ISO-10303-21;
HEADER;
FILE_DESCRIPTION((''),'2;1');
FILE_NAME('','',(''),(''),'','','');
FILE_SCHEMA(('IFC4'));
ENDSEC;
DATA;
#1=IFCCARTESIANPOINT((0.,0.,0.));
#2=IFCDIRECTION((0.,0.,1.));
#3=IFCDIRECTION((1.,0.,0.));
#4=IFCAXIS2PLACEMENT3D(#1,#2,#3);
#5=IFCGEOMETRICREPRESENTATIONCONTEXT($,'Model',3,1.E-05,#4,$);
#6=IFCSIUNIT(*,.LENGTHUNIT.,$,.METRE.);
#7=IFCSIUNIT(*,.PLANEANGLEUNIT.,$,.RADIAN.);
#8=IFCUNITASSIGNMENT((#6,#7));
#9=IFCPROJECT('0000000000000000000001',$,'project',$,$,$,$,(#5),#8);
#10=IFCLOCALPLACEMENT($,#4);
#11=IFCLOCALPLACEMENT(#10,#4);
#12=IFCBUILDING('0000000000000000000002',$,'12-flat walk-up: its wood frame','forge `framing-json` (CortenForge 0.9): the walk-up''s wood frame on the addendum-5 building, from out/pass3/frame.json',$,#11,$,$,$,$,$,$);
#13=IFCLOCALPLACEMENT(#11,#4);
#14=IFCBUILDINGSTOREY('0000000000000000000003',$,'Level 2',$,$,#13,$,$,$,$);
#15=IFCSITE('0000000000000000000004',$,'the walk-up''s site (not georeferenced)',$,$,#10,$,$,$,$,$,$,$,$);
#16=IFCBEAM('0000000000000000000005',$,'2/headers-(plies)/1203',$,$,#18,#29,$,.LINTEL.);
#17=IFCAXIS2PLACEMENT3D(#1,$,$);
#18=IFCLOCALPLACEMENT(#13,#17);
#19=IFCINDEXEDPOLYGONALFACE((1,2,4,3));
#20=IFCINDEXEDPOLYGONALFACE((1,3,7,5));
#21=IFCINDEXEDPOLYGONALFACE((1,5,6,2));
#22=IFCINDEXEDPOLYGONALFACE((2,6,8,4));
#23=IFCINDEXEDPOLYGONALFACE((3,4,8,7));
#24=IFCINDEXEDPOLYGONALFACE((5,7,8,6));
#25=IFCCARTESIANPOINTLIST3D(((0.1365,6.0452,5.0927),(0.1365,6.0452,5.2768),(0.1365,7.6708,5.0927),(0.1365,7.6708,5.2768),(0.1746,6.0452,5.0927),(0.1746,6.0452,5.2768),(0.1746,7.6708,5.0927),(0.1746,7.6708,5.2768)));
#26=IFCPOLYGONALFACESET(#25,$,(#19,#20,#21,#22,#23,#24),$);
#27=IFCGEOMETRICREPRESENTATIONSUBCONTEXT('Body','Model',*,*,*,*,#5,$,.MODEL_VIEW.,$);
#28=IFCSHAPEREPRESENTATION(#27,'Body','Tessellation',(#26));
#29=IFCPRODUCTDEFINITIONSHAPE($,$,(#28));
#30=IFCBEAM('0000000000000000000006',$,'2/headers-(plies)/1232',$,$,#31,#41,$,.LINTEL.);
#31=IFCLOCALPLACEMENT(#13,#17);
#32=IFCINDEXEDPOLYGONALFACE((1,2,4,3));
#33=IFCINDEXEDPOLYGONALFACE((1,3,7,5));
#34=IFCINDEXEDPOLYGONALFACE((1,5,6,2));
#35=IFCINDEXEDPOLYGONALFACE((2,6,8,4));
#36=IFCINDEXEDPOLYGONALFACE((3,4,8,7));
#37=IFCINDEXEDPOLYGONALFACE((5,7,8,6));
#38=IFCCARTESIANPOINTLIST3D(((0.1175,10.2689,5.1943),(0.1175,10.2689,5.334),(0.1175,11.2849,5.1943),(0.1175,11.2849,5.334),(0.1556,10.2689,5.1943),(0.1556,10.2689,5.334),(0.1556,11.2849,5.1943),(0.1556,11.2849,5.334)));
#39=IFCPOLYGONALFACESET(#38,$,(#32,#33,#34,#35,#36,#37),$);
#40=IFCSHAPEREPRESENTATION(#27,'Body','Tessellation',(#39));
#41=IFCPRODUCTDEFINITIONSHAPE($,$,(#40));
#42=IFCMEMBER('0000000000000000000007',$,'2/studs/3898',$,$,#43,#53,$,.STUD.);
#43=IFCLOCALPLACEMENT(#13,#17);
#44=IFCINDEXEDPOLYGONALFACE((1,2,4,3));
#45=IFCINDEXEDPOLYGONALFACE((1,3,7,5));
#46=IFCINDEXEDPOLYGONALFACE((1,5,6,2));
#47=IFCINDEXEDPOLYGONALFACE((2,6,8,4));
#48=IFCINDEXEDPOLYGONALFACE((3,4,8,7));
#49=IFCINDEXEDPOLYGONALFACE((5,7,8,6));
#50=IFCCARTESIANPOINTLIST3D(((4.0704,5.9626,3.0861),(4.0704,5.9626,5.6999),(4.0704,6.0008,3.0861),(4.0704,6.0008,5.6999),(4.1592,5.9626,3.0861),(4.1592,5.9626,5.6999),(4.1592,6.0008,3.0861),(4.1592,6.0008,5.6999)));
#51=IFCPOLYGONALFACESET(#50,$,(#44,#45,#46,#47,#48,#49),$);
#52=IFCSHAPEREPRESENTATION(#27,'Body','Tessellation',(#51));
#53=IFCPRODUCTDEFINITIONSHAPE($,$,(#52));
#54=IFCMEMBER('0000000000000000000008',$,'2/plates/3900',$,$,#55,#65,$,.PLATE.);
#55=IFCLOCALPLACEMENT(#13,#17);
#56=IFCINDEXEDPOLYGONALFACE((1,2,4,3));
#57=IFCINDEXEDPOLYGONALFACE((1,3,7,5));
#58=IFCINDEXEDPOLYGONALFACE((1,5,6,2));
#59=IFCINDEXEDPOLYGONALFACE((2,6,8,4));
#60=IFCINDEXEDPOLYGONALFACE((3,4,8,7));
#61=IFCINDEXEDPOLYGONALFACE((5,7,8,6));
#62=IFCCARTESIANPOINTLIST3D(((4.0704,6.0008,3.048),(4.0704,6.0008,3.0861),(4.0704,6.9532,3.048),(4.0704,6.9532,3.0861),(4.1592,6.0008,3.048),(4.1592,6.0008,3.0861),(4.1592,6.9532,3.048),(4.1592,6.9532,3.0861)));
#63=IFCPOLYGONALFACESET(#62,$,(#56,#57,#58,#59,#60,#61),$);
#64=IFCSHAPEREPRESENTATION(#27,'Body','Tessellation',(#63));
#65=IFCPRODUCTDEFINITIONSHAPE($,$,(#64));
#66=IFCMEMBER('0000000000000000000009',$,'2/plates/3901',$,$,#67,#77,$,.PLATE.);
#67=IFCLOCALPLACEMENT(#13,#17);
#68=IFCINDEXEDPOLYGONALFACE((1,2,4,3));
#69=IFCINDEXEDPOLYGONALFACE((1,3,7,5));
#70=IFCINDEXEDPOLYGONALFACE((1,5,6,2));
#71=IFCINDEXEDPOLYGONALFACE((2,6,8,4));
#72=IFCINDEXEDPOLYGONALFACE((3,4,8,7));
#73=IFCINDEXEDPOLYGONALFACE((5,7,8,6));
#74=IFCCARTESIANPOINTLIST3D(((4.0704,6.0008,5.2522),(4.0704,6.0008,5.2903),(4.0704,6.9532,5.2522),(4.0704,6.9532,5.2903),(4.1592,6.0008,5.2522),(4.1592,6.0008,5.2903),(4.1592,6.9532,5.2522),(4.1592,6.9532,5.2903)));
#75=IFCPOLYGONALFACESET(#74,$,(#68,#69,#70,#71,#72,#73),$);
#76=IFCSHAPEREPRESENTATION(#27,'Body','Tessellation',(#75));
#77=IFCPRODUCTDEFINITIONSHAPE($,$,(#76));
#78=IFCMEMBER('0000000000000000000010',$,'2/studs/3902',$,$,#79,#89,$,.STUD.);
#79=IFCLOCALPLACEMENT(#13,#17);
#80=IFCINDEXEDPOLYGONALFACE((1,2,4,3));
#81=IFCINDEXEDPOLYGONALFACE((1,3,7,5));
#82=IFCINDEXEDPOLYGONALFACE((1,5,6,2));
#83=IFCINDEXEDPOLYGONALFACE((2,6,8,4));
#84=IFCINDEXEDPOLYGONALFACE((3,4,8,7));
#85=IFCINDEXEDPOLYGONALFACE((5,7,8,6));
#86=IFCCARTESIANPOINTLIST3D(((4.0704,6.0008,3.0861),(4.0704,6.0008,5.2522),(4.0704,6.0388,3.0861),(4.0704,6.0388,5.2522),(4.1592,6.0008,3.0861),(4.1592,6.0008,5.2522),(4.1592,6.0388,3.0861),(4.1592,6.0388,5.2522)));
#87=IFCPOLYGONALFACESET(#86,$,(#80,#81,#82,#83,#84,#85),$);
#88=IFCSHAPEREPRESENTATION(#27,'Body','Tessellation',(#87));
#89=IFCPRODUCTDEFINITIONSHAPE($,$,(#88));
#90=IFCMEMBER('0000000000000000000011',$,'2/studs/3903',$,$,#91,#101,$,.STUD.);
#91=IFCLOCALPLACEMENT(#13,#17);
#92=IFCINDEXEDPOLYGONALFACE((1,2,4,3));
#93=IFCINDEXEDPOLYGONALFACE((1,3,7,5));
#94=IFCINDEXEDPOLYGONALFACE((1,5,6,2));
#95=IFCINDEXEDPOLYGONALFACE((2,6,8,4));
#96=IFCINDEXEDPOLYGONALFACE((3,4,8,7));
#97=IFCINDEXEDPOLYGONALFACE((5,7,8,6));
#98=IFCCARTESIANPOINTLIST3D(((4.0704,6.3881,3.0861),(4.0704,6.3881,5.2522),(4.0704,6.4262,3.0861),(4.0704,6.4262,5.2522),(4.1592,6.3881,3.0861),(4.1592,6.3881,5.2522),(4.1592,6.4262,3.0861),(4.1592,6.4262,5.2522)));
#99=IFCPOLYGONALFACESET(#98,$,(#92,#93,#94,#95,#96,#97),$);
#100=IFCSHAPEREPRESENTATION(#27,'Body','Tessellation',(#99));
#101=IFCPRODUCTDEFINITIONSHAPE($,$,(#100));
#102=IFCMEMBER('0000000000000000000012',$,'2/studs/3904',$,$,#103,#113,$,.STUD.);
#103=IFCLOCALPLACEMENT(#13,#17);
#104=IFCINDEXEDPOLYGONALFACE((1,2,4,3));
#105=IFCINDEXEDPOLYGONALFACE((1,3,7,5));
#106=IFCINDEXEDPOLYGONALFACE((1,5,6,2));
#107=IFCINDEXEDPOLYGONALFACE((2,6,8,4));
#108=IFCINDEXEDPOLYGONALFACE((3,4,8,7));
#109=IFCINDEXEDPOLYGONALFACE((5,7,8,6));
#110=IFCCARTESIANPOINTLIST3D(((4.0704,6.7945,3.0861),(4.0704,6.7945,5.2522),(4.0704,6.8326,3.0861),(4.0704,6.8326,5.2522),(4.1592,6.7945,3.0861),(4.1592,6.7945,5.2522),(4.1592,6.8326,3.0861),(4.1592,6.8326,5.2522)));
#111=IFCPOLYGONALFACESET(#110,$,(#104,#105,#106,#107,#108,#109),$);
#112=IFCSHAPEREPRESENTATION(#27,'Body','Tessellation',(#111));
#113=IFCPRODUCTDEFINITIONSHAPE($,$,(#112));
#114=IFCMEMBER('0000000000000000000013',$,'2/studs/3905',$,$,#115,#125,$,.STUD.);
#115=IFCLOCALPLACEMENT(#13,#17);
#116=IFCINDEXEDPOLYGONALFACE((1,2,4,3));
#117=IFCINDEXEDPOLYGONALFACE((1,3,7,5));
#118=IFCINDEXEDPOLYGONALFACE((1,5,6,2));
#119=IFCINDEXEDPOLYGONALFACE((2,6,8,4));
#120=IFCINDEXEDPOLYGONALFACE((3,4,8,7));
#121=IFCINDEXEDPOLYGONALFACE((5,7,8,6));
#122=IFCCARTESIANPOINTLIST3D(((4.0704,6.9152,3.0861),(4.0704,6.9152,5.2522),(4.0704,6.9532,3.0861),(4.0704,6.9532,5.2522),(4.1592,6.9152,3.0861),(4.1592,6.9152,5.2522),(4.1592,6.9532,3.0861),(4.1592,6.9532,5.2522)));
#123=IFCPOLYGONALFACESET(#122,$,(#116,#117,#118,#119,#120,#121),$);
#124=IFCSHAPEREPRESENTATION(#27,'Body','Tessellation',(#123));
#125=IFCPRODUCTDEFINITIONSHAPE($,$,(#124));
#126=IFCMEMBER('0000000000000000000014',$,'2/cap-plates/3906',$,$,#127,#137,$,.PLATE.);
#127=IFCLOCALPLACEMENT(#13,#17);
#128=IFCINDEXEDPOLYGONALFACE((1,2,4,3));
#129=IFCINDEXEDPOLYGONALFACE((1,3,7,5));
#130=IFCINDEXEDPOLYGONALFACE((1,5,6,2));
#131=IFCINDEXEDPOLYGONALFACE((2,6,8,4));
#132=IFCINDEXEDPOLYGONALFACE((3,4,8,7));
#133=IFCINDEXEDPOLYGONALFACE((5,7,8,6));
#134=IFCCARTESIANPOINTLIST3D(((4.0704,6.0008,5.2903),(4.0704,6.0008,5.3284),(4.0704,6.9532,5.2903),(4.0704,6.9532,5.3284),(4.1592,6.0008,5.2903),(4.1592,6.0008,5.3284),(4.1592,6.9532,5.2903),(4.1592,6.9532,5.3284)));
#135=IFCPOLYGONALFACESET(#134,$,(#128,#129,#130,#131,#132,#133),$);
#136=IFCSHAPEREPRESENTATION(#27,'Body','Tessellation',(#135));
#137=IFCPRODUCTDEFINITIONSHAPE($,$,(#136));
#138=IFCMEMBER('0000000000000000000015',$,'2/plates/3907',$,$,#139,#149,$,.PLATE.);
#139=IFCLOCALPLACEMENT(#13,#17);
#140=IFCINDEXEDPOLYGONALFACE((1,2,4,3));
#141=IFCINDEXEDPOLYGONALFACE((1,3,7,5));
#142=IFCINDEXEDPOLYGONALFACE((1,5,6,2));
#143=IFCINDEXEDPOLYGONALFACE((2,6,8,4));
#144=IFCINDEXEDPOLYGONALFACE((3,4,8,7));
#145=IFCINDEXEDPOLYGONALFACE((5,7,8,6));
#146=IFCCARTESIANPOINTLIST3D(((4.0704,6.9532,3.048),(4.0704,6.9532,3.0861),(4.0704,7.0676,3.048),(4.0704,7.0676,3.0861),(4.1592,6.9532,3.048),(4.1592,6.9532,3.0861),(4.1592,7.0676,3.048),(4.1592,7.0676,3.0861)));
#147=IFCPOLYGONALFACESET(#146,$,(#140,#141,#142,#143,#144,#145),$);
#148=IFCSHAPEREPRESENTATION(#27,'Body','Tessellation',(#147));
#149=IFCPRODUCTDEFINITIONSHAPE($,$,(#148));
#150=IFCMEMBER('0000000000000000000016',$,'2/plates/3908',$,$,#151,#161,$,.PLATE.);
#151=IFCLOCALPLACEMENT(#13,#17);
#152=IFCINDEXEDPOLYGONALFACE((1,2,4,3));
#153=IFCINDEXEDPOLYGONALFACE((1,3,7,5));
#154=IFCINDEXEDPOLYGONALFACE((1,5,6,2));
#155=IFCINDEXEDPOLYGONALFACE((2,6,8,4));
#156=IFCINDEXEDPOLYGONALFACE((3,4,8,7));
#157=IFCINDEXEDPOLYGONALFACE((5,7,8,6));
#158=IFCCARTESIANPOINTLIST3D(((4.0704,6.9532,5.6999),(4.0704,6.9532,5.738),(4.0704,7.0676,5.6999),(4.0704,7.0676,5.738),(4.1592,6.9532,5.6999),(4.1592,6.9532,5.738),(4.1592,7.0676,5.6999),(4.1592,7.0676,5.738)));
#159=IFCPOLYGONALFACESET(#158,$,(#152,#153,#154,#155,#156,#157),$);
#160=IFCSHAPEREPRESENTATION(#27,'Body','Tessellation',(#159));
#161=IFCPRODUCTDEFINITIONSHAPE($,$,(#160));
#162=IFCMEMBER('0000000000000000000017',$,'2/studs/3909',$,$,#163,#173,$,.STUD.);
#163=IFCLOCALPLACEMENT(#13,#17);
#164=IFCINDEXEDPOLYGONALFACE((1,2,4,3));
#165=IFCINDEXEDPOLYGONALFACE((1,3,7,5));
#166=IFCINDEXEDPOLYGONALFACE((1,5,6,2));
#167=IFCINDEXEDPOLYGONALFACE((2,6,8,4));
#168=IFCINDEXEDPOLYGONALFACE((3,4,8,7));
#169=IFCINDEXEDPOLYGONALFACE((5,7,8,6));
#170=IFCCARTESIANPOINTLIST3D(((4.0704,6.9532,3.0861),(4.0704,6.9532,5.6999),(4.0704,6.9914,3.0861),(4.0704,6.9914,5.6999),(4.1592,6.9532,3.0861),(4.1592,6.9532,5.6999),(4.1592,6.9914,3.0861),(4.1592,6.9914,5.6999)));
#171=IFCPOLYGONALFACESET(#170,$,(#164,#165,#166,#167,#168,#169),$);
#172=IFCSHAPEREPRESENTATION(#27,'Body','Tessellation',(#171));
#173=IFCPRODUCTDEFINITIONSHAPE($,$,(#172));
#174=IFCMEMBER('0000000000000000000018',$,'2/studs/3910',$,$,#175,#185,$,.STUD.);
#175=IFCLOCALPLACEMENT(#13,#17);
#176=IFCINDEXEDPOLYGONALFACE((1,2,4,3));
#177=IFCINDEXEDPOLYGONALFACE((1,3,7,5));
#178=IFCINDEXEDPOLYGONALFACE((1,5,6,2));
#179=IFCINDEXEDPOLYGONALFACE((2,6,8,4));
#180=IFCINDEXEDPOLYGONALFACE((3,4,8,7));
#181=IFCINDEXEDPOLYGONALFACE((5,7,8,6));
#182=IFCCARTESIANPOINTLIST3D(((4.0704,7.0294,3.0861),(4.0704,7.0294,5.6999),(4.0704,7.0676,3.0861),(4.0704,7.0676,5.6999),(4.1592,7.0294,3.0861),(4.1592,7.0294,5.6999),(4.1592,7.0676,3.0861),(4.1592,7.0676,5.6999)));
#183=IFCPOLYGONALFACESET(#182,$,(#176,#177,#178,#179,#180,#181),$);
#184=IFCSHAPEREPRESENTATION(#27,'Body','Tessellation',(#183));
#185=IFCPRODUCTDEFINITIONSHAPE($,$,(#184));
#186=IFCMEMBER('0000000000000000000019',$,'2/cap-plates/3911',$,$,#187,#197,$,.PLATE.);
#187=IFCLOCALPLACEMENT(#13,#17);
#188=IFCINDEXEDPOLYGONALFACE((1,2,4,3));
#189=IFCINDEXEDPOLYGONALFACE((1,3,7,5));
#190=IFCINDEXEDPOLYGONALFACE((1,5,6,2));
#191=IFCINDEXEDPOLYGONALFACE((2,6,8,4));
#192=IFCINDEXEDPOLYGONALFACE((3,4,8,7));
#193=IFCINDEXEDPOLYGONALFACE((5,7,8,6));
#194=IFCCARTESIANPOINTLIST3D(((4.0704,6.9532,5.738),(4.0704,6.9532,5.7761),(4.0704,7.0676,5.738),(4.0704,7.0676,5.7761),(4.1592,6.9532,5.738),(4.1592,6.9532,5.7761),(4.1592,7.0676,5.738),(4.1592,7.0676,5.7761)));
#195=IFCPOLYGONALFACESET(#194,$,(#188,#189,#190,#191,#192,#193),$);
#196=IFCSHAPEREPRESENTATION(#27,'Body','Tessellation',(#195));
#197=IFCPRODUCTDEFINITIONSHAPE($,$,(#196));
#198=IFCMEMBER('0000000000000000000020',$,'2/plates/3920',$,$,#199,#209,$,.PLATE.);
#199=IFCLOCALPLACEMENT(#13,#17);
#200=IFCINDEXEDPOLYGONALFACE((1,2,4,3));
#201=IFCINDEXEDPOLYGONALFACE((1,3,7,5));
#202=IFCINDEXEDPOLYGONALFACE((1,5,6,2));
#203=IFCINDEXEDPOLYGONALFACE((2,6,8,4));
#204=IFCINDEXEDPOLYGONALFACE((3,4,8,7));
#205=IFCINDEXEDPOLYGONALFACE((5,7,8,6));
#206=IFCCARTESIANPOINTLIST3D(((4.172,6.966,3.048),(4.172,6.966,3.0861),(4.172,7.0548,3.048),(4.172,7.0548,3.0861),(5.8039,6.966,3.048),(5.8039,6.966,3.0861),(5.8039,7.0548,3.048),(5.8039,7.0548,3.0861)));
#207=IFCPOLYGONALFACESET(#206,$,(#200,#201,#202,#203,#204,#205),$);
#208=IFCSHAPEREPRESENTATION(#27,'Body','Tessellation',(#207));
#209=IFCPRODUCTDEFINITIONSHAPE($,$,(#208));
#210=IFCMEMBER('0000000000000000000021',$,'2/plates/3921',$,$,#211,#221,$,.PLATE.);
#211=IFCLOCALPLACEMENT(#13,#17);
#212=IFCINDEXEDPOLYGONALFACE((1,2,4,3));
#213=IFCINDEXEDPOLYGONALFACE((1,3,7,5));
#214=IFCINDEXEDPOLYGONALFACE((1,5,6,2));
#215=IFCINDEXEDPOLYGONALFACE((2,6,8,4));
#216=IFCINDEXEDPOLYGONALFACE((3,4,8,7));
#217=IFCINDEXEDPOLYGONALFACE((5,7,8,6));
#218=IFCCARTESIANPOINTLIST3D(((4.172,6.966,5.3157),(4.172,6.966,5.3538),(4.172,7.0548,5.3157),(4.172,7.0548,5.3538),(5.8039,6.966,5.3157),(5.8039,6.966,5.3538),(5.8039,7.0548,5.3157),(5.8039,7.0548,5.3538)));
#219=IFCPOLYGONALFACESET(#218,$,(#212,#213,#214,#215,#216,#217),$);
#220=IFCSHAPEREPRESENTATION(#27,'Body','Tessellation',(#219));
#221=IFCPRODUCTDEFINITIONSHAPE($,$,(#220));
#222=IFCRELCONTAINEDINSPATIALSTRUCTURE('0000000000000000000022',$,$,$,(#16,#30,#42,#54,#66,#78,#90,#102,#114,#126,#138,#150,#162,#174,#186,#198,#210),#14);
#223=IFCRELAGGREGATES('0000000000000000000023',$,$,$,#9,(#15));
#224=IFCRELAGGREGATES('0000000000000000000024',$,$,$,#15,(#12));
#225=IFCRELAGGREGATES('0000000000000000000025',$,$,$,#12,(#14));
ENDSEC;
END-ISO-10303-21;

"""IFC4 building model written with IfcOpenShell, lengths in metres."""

from ifc_helpers import new_model, si_unit, frame, frame_2d, origin, origin_with_axes, place, context, subcontext, project, spatial, rectangle, extrude, element, save


model = new_model("IFC4")

# Units and contexts
model_context = context("Model", 3, precision=1e-05, world=origin_with_axes())
body_context = subcontext(model_context, "Body", "Model", "MODEL_VIEW")
ifc_project = project(units=[si_unit("LENGTHUNIT", "METRE"), si_unit("PLANEANGLEUNIT", "RADIAN")], contexts=[model_context])

# Site, building, storey
site_placement = place(None, origin_with_axes())
site = spatial("IfcSite", under=ifc_project, at=site_placement, Name="the walk-up's site (not georeferenced)")
building_placement = place(site_placement, origin_with_axes())
building = spatial("IfcBuilding", under=site, at=building_placement, Name="12-flat walk-up: its wood frame", Description="forge `framing-json` (CortenForge 0.9): the walk-up's wood frame on the addendum-5 building, from out/pass3/frame.json")
storey_placement = place(building_placement, origin_with_axes())
storey = spatial("IfcBuildingStorey", under=building, at=storey_placement, Name="Level 2")

# Beams
beam_1_placement = place(storey_placement, frame((0.1365, 6.0452, 5.0927), z_axis=(0.0, 0.0, 1.0), x_axis=(1.0, 0.0, 0.0)))
element("IfcBeam", 1, at=beam_1_placement, inside=storey, Name="2/headers-(plies)/1203", PredefinedType="LINTEL", context=body_context, shape_type="SweptSolid", body=[
    extrude(rectangle(XDim=0.0381, YDim=1.6256, at=frame_2d((0.019, 0.8128))), origin(), (0.0, 0.0, 1.0), 0.1841),
])
beam_2_placement = place(storey_placement, frame((0.1175, 10.2689, 5.1943), z_axis=(0.0, 0.0, 1.0), x_axis=(1.0, 0.0, 0.0)))
element("IfcBeam", 2, at=beam_2_placement, inside=storey, Name="2/headers-(plies)/1232", PredefinedType="LINTEL", context=body_context, shape_type="SweptSolid", body=[
    extrude(rectangle(XDim=0.0381, YDim=1.016, at=frame_2d((0.019, 0.508))), origin(), (0.0, 0.0, 1.0), 0.1397),
])

# Members
member_1_placement = place(storey_placement, frame((4.0704, 5.9627, 3.0861), z_axis=(0.0, 0.0, 1.0), x_axis=(1.0, 0.0, 0.0)))
element("IfcMember", 3, at=member_1_placement, inside=storey, Name="2/studs/3898", PredefinedType="STUD", context=body_context, shape_type="SweptSolid", body=[
    extrude(rectangle(XDim=0.0889, YDim=0.0381, at=frame_2d((0.0444, 0.0191))), origin(), (0.0, 0.0, 1.0), 2.6138),
])
for number, where, z_axis, x_axis, name in (
    (4, (4.0704, 6.0008, 3.048), (0.0, 0.0, 1.0), (1.0, 0.0, 0.0), "2/plates/3900"),
    (5, (4.0704, 6.0008, 5.2522), (0.0, 0.0, 1.0), (1.0, 0.0, 0.0), "2/plates/3901"),
):
    element("IfcMember", number, at=place(storey_placement, frame(where, z_axis=z_axis, x_axis=x_axis)), inside=storey, Name=name, PredefinedType="PLATE", context=body_context, shape_type="SweptSolid", body=[
        extrude(rectangle(XDim=0.0889, YDim=0.9525, at=frame_2d((0.0444, 0.4762))), origin(), (0.0, 0.0, 1.0), 0.0381),
    ])
for number, where, z_axis, x_axis, name in (
    (6, (4.0704, 6.0008, 3.0861), (0.0, 0.0, 1.0), (1.0, 0.0, 0.0), "2/studs/3902"),
    (7, (4.0704, 6.3881, 3.0861), (0.0, 0.0, 1.0), (1.0, 0.0, 0.0), "2/studs/3903"),
    (8, (4.0704, 6.7945, 3.0861), (0.0, 0.0, 1.0), (1.0, 0.0, 0.0), "2/studs/3904"),
    (9, (4.0704, 6.9151, 3.0861), (0.0, 0.0, 1.0), (1.0, 0.0, 0.0), "2/studs/3905"),
):
    element("IfcMember", number, at=place(storey_placement, frame(where, z_axis=z_axis, x_axis=x_axis)), inside=storey, Name=name, PredefinedType="STUD", context=body_context, shape_type="SweptSolid", body=[
        extrude(rectangle(XDim=0.0889, YDim=0.0381, at=frame_2d((0.0444, 0.0191))), origin(), (0.0, 0.0, 1.0), 2.1661),
    ])
member_2_placement = place(storey_placement, frame((4.0704, 6.0008, 5.2903), z_axis=(0.0, 0.0, 1.0), x_axis=(1.0, 0.0, 0.0)))
element("IfcMember", 10, at=member_2_placement, inside=storey, Name="2/cap-plates/3906", PredefinedType="PLATE", context=body_context, shape_type="SweptSolid", body=[
    extrude(rectangle(XDim=0.0889, YDim=0.9525, at=frame_2d((0.0444, 0.4762))), origin(), (0.0, 0.0, 1.0), 0.0381),
])
for number, where, z_axis, x_axis, name in (
    (11, (4.0704, 6.9532, 3.048), (0.0, 0.0, 1.0), (1.0, 0.0, 0.0), "2/plates/3907"),
    (12, (4.0704, 6.9532, 5.6999), (0.0, 0.0, 1.0), (1.0, 0.0, 0.0), "2/plates/3908"),
):
    element("IfcMember", number, at=place(storey_placement, frame(where, z_axis=z_axis, x_axis=x_axis)), inside=storey, Name=name, PredefinedType="PLATE", context=body_context, shape_type="SweptSolid", body=[
        extrude(rectangle(XDim=0.0889, YDim=0.1143, at=frame_2d((0.0444, 0.0572))), origin(), (0.0, 0.0, 1.0), 0.0381),
    ])
for number, where, z_axis, x_axis, name in (
    (13, (4.0704, 6.9532, 3.0861), (0.0, 0.0, 1.0), (1.0, 0.0, 0.0), "2/studs/3909"),
    (14, (4.0704, 7.0294, 3.0861), (0.0, 0.0, 1.0), (1.0, 0.0, 0.0), "2/studs/3910"),
):
    element("IfcMember", number, at=place(storey_placement, frame(where, z_axis=z_axis, x_axis=x_axis)), inside=storey, Name=name, PredefinedType="STUD", context=body_context, shape_type="SweptSolid", body=[
        extrude(rectangle(XDim=0.0889, YDim=0.0381, at=frame_2d((0.0444, 0.0191))), origin(), (0.0, 0.0, 1.0), 2.6138),
    ])
member_3_placement = place(storey_placement, frame((4.0704, 6.9532, 5.738), z_axis=(0.0, 0.0, 1.0), x_axis=(1.0, 0.0, 0.0)))
element("IfcMember", 15, at=member_3_placement, inside=storey, Name="2/cap-plates/3911", PredefinedType="PLATE", context=body_context, shape_type="SweptSolid", body=[
    extrude(rectangle(XDim=0.0889, YDim=0.1143, at=frame_2d((0.0444, 0.0572))), origin(), (0.0, 0.0, 1.0), 0.0381),
])
for number, where, z_axis, x_axis, name in (
    (16, (4.1719, 6.966, 3.048), (0.0, 0.0, 1.0), (1.0, 0.0, 0.0), "2/plates/3920"),
    (17, (4.1719, 6.966, 5.3157), (0.0, 0.0, 1.0), (1.0, 0.0, 0.0), "2/plates/3921"),
):
    element("IfcMember", number, at=place(storey_placement, frame(where, z_axis=z_axis, x_axis=x_axis)), inside=storey, Name=name, PredefinedType="PLATE", context=body_context, shape_type="SweptSolid", body=[
        extrude(rectangle(XDim=1.6319, YDim=0.0889, at=frame_2d((0.816, 0.0444))), origin(), (0.0, 0.0, 1.0), 0.0381),
    ])

save(model, "model.ifc")
